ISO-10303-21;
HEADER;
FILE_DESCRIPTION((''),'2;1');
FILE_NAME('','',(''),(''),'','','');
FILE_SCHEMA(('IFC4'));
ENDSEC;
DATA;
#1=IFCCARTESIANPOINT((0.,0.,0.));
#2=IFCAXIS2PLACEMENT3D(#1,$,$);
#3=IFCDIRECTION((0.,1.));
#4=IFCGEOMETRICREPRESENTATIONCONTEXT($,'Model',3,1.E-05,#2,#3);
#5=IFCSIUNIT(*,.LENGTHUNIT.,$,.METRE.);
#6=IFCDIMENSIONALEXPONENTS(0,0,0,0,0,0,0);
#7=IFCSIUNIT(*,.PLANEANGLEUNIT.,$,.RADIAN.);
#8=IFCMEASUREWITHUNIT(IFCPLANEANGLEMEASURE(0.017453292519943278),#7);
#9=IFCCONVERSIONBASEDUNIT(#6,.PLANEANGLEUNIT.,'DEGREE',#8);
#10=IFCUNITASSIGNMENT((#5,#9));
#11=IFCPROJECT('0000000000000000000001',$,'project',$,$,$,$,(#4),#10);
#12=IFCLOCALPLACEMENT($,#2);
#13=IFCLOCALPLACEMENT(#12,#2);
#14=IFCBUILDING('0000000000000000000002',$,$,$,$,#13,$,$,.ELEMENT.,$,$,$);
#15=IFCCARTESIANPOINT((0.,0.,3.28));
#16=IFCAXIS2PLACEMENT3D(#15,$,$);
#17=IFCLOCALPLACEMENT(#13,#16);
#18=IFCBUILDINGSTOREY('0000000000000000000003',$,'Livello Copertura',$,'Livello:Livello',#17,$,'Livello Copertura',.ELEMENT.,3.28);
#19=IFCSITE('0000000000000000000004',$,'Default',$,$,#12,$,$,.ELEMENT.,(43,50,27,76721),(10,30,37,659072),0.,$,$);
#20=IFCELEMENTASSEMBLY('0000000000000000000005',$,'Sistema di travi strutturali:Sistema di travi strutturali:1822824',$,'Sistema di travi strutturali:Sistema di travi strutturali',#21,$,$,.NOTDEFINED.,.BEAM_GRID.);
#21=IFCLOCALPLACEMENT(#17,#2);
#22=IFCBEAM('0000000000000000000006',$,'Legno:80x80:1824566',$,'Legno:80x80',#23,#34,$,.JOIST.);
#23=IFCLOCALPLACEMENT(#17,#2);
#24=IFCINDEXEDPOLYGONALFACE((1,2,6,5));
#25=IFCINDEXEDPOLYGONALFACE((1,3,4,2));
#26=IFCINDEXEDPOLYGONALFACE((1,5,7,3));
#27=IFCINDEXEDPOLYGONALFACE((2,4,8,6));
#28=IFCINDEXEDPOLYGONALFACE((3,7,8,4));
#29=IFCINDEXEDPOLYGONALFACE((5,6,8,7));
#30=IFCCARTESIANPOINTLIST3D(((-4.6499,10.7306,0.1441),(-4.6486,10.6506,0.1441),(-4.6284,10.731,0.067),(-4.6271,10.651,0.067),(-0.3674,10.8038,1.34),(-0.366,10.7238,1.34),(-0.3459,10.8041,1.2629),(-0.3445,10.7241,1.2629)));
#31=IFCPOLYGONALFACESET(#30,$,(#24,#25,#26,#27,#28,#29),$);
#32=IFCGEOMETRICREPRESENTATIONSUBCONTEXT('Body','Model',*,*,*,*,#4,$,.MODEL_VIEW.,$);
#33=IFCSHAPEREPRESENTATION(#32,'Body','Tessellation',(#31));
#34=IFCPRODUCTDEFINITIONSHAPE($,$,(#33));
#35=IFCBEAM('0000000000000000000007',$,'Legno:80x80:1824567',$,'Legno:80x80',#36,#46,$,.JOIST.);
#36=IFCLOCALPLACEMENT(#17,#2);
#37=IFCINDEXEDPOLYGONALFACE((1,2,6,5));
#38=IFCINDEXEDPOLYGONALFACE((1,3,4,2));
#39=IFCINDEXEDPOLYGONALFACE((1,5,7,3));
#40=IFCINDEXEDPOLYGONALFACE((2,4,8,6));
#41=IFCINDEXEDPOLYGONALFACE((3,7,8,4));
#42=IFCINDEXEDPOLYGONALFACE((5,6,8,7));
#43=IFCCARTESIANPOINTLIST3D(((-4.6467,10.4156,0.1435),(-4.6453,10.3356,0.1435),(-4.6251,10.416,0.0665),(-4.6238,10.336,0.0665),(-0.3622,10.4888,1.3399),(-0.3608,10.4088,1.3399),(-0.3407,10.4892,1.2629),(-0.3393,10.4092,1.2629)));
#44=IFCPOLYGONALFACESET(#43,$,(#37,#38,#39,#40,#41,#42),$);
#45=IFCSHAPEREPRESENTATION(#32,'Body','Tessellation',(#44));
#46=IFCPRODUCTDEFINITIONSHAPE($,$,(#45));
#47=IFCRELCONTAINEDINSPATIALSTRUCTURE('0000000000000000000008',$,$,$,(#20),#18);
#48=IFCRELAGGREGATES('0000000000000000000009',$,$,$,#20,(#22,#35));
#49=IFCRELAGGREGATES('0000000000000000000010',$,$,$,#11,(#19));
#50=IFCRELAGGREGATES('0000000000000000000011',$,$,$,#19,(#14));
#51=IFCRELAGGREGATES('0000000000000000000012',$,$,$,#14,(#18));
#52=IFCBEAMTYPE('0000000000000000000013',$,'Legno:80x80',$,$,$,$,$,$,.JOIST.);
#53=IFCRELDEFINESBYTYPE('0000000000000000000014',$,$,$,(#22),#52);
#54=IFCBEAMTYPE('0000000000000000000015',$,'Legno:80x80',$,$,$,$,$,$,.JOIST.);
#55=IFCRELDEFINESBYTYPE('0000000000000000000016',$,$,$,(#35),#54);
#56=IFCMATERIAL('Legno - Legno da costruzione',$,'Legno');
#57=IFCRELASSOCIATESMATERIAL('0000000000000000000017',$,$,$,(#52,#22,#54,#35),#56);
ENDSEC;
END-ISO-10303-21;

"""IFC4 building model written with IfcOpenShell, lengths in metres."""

from ifc_helpers import new_model, entity, si_unit, converted_unit, direction, frame, origin, place, context, subcontext, project, spatial, indexed_curve, outline, extrude, source, transform, mapped, material, type_object, type_shapes, element, aggregate, save


model = new_model("IFC4")

# Units and contexts
model_context = context("Model", 3, precision=1e-05, world=origin(), true_north=direction((0.0, 1.0)))
body_context = subcontext(model_context, "Body", "Model", "MODEL_VIEW")
ifc_project = project(units=[si_unit("LENGTHUNIT", "METRE"), converted_unit("PLANEANGLEUNIT", "DEGREE", entity("IfcPlaneAngleMeasure", 0.017453292519943278), si_unit("PLANEANGLEUNIT", "RADIAN"), dimensions=[0, 0, 0, 0, 0, 0, 0])], contexts=[model_context])

# Site, building, storey
site_placement = place(None, origin())
site = spatial("IfcSite", under=ifc_project, at=site_placement, Name="Default", CompositionType="ELEMENT", RefLatitude=(43, 50, 27, 76721), RefLongitude=(10, 30, 37, 659072), RefElevation=0.0)
building_placement = place(site_placement, origin())
building = spatial("IfcBuilding", under=site, at=building_placement, CompositionType="ELEMENT")
storey_placement = place(building_placement, frame((0.0, 0.0, 3.28)))
storey = spatial("IfcBuildingStorey", under=building, at=storey_placement, Name="Livello Copertura", ObjectType="Livello:Livello", LongName="Livello Copertura", CompositionType="ELEMENT", Elevation=3.28)

# Shared definitions
ifc_material_1 = material(Name="Legno - Legno da costruzione", Category="Legno")

# Element assembly, beams
assembly_1_placement = place(storey_placement, origin())
assembly_1 = element("IfcElementAssembly", 1, at=assembly_1_placement, inside=storey, Name="Sistema di travi strutturali:Sistema di travi strutturali:1822824", ObjectType="Sistema di travi strutturali:Sistema di travi strutturali", AssemblyPlace="NOTDEFINED", PredefinedType="BEAM_GRID")
beam_type_1 = type_object("IfcBeamType", Name="Legno:80x80", PredefinedType="JOIST", material=ifc_material_1)
shared_shape_1 = source(origin(), body_context, "Body", "SweptSolid", [
    extrude(outline(indexed_curve([(-2.2235, -0.04), (2.2235, -0.04), (2.2235, 0.04), (-2.2235, 0.04), (-2.2235, -0.04)], self_intersect=False)), frame((0.0, 0.0, -0.04), z_axis=(0.0, 0.0, 1.0), x_axis=(-1.0, 0.0, 0.0)), (0.0, 0.0, 1.0), 0.08),
])
type_shapes(beam_type_1, [shared_shape_1])
beam_1_placement = place(assembly_1_placement, frame((-2.4972, 10.7274, 0.7035), z_axis=(-0.268881, -0.004594, 0.963163), x_axis=(0.963022, 0.016456, 0.26892)))
beam_1 = element("IfcBeam", 2, at=beam_1_placement, type_object=beam_type_1, material=ifc_material_1, Name="Legno:80x80:1824566", ObjectType="Legno:80x80", PredefinedType="JOIST", context=body_context, shape_type="MappedRepresentation", body=[
    mapped(shared_shape_1, transform((0.0, 0.0, 0.0), scale=1.0)),
])
beam_type_2 = type_object("IfcBeamType", Name="Legno:80x80", PredefinedType="JOIST", material=ifc_material_1)
shared_shape_2 = source(origin(), body_context, "Body", "SweptSolid", [
    extrude(outline(indexed_curve([(-2.2245, -0.04), (2.2245, -0.04), (2.2245, 0.04), (-2.2245, 0.04), (-2.2245, -0.04)], self_intersect=False)), frame((0.0, 0.0, -0.04), z_axis=(0.0, 0.0, 1.0), x_axis=(-1.0, 0.0, 0.0)), (0.0, 0.0, 1.0), 0.08),
])
type_shapes(beam_type_2, [shared_shape_2])
beam_2_placement = place(assembly_1_placement, frame((-2.493, 10.4124, 0.7032), z_axis=(-0.268881, -0.004594, 0.963163), x_axis=(0.963022, 0.016456, 0.26892)))
beam_2 = element("IfcBeam", 3, at=beam_2_placement, type_object=beam_type_2, material=ifc_material_1, Name="Legno:80x80:1824567", ObjectType="Legno:80x80", PredefinedType="JOIST", context=body_context, shape_type="MappedRepresentation", body=[
    mapped(shared_shape_2, transform((0.0, 0.0, 0.0), scale=1.0)),
])
aggregate(assembly_1, [beam_1, beam_2])

save(model, "model.ifc")
